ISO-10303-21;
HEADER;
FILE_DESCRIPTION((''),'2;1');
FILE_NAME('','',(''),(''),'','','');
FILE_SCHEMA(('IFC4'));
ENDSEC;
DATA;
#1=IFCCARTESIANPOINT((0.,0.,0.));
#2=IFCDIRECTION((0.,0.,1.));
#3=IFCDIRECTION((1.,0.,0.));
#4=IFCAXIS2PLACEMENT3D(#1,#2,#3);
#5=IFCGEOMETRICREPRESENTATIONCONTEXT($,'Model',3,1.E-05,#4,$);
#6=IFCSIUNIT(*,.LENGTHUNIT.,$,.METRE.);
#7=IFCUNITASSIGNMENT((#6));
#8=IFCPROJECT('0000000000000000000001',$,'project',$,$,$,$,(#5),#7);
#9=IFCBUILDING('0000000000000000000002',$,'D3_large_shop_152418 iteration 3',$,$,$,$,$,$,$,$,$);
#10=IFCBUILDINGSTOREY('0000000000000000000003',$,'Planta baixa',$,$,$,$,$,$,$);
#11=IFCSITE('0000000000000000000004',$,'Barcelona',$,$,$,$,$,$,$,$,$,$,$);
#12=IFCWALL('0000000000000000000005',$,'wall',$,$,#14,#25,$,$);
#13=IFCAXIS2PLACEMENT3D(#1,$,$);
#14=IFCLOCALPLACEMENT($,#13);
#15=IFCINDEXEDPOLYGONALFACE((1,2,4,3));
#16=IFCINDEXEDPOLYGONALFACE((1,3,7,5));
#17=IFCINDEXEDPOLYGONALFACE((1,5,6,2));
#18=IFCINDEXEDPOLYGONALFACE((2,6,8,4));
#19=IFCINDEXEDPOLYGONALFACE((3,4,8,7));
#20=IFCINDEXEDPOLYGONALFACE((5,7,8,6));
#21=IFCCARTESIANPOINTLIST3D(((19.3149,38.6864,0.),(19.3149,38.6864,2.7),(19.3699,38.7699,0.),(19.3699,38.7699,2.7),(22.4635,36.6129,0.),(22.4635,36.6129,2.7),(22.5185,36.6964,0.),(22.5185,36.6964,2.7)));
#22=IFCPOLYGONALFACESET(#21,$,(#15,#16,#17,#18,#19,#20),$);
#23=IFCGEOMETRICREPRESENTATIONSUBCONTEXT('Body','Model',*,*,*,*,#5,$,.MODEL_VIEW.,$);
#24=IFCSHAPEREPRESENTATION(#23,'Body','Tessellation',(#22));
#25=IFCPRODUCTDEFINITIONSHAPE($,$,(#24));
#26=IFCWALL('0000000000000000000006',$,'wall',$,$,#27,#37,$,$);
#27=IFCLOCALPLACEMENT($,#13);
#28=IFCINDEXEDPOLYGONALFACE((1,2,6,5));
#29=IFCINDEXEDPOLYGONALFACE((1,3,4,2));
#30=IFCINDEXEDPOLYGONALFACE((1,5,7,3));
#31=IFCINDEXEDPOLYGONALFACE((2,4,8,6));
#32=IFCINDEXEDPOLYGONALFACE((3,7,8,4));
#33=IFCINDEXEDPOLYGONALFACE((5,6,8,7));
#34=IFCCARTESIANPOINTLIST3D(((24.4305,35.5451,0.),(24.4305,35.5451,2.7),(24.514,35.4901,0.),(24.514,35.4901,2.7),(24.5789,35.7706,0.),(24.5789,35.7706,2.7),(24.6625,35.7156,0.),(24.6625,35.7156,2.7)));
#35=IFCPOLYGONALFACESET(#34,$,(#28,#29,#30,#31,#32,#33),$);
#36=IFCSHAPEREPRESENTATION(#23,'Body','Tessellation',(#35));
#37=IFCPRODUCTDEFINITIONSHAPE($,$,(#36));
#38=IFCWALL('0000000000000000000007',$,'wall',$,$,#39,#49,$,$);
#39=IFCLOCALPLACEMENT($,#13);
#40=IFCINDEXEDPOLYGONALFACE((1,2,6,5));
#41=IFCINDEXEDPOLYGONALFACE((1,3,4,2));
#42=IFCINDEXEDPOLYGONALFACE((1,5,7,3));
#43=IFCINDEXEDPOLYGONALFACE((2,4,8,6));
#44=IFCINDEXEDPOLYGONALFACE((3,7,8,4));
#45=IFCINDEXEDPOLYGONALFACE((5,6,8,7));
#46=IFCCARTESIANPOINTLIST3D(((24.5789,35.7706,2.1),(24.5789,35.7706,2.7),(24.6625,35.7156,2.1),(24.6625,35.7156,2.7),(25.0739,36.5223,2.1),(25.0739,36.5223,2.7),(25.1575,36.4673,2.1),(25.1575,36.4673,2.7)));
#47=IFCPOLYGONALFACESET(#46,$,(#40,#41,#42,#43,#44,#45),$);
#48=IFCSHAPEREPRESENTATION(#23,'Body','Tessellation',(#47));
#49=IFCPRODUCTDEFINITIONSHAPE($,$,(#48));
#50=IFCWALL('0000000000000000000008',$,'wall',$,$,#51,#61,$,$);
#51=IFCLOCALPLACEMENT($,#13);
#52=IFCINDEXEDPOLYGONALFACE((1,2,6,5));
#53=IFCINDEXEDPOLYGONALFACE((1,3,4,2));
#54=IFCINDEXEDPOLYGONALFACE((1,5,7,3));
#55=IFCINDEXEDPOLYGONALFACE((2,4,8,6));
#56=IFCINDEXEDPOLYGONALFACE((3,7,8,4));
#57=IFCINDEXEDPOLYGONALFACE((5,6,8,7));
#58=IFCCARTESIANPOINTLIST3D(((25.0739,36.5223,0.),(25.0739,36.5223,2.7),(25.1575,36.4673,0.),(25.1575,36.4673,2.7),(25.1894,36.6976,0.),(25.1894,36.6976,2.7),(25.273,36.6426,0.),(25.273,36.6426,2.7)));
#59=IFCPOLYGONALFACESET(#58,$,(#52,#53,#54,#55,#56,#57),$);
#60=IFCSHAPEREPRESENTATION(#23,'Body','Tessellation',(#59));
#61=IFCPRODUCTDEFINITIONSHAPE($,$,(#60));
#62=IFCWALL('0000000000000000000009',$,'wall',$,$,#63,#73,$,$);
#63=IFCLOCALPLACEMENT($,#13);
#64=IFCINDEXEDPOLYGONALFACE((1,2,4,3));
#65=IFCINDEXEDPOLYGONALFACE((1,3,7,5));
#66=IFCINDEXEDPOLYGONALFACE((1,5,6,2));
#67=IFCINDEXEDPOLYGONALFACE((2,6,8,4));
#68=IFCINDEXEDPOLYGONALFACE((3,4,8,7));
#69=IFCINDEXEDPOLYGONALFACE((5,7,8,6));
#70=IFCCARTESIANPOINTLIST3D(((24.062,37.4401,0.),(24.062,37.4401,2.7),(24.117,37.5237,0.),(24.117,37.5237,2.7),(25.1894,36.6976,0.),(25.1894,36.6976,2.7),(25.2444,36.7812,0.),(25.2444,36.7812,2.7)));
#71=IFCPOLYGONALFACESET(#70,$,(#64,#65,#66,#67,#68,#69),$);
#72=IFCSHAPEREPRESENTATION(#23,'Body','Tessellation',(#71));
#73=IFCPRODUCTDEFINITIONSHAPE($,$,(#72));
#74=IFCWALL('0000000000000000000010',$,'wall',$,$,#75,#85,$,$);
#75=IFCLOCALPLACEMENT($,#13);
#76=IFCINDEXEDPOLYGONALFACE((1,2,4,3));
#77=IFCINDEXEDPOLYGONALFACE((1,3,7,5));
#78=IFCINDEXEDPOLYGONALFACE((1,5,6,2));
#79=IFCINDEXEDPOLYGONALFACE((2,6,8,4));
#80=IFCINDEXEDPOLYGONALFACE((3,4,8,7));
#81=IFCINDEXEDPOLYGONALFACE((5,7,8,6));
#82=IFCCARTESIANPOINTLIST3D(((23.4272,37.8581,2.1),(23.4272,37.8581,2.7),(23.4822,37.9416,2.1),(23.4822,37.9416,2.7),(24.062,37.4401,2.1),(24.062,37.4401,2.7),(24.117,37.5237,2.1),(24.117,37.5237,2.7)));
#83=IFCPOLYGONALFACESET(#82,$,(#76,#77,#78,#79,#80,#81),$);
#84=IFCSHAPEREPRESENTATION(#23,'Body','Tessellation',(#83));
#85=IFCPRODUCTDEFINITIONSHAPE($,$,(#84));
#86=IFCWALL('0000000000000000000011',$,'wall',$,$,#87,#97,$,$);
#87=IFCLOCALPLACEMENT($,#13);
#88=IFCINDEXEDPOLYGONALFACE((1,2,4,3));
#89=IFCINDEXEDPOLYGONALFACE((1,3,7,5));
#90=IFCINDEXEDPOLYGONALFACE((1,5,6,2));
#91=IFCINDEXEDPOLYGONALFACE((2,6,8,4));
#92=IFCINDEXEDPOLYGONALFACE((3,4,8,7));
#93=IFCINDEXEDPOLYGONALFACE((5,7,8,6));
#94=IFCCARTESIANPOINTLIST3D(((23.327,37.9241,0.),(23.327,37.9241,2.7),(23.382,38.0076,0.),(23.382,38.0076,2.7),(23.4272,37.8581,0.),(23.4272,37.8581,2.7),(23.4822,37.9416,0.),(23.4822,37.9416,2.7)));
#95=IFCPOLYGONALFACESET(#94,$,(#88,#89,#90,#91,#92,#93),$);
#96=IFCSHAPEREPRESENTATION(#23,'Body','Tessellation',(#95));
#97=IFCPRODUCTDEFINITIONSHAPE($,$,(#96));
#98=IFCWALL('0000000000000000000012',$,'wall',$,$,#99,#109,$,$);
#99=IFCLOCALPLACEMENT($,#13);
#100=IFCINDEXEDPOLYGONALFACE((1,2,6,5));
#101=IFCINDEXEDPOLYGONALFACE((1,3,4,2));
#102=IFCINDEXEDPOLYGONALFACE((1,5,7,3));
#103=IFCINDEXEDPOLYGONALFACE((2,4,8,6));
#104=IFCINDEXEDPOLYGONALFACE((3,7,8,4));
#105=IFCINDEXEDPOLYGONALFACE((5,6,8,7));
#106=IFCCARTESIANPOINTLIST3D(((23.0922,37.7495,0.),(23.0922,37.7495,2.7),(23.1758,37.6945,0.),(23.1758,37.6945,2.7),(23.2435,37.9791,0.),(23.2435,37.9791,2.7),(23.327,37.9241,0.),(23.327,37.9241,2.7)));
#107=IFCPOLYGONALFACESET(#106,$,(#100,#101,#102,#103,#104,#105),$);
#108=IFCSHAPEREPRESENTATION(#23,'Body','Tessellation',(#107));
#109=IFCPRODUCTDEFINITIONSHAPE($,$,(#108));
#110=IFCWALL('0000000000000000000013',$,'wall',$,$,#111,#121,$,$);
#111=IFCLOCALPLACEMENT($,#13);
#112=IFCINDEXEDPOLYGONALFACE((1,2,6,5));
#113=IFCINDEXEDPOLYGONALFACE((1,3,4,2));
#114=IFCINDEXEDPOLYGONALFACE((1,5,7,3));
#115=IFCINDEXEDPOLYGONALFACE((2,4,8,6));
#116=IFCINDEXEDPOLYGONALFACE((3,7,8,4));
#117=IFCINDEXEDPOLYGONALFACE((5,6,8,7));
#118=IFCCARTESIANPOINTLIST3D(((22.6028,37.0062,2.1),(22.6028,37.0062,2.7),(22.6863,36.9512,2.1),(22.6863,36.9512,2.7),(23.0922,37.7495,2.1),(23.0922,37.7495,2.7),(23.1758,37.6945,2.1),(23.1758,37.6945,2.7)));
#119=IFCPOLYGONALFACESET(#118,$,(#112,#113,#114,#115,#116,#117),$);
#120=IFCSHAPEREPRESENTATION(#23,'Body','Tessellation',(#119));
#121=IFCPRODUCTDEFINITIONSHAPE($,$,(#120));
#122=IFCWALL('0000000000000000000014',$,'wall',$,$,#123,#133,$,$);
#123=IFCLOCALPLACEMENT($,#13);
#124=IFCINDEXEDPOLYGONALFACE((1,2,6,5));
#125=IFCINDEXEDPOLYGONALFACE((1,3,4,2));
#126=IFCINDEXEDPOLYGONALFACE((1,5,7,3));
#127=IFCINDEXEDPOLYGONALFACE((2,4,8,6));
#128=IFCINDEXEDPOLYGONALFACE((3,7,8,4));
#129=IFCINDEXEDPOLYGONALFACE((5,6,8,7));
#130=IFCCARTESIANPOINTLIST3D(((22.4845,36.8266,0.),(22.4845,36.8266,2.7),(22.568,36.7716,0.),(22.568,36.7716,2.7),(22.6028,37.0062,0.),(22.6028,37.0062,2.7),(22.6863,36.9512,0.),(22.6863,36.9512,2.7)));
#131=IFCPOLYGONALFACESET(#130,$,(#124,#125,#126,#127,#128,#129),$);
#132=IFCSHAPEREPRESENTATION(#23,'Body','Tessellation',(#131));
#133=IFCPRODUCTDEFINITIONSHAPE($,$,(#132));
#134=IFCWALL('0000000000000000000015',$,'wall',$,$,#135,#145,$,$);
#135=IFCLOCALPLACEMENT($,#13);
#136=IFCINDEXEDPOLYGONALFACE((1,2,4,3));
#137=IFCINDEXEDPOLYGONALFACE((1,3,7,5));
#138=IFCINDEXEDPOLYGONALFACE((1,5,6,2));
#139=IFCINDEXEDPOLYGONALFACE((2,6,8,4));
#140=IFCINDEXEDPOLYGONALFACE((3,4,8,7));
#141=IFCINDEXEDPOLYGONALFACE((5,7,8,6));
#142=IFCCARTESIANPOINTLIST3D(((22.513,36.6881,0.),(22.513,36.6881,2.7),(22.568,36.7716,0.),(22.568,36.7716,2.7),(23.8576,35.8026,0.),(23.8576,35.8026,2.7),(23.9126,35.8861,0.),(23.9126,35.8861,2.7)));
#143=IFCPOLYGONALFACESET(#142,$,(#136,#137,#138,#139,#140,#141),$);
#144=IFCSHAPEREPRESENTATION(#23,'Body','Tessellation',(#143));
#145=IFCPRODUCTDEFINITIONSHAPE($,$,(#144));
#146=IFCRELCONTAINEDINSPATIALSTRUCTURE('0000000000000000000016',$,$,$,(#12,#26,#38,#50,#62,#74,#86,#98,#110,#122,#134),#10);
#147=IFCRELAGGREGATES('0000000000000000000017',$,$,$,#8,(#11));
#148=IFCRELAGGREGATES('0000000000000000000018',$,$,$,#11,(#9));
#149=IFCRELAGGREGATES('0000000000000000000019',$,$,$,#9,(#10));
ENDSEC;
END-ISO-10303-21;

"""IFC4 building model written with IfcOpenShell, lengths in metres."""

from ifc_helpers import new_model, si_unit, frame, origin, origin_with_axes, place, context, subcontext, project, spatial, polyline, outline, extrude, element, save


model = new_model("IFC4")

# Units and contexts
model_context = context("Model", 3, precision=1e-05, world=origin_with_axes())
body_context = subcontext(model_context, "Body", "Model", "MODEL_VIEW")
ifc_project = project(units=[si_unit("LENGTHUNIT", "METRE")], contexts=[model_context])

# Site, building, storey
site = spatial("IfcSite", under=ifc_project, Name="Barcelona")
building = spatial("IfcBuilding", under=site, Name="D3_large_shop_152418 iteration 3")
storey = spatial("IfcBuildingStorey", under=building, Name="Planta baixa")

# Walls
wall_1_placement = place(None, origin_with_axes())
element("IfcWall", 1, at=wall_1_placement, inside=storey, Name="wall", context=body_context, shape_type="SweptSolid", body=[
    extrude(outline(polyline([(22.4635, 36.6129), (19.3149, 38.6864), (19.3699, 38.7699), (22.5185, 36.6964), (22.4635, 36.6129)])), origin(), (0.0, 0.0, 1.0), 2.7),
])
wall_2_placement = place(None, origin_with_axes())
element("IfcWall", 2, at=wall_2_placement, inside=storey, Name="wall", context=body_context, shape_type="SweptSolid", body=[
    extrude(outline(polyline([(24.4305, 35.5451), (24.5789, 35.7706), (24.6625, 35.7156), (24.514, 35.4901), (24.4305, 35.5451)])), origin(), (0.0, 0.0, 1.0), 2.7),
])
wall_3_placement = place(None, origin_with_axes())
element("IfcWall", 3, at=wall_3_placement, inside=storey, Name="wall", context=body_context, shape_type="SweptSolid", body=[
    extrude(outline(polyline([(24.5789, 35.7706), (25.0739, 36.5223), (25.1575, 36.4673), (24.6625, 35.7156), (24.5789, 35.7706)])), frame((0.0, 0.0, 2.1)), (0.0, 0.0, 1.0), 0.6),
])
wall_4_placement = place(None, origin_with_axes())
element("IfcWall", 4, at=wall_4_placement, inside=storey, Name="wall", context=body_context, shape_type="SweptSolid", body=[
    extrude(outline(polyline([(25.0739, 36.5223), (25.1894, 36.6976), (25.273, 36.6426), (25.1575, 36.4673), (25.0739, 36.5223)])), origin(), (0.0, 0.0, 1.0), 2.7),
])
wall_5_placement = place(None, origin_with_axes())
element("IfcWall", 5, at=wall_5_placement, inside=storey, Name="wall", context=body_context, shape_type="SweptSolid", body=[
    extrude(outline(polyline([(25.1894, 36.6976), (24.062, 37.4401), (24.117, 37.5237), (25.2444, 36.7812), (25.1894, 36.6976)])), origin(), (0.0, 0.0, 1.0), 2.7),
])
wall_6_placement = place(None, origin_with_axes())
element("IfcWall", 6, at=wall_6_placement, inside=storey, Name="wall", context=body_context, shape_type="SweptSolid", body=[
    extrude(outline(polyline([(24.062, 37.4401), (23.4272, 37.8581), (23.4822, 37.9416), (24.117, 37.5237), (24.062, 37.4401)])), frame((0.0, 0.0, 2.1)), (0.0, 0.0, 1.0), 0.6),
])
wall_7_placement = place(None, origin_with_axes())
element("IfcWall", 7, at=wall_7_placement, inside=storey, Name="wall", context=body_context, shape_type="SweptSolid", body=[
    extrude(outline(polyline([(23.4272, 37.8581), (23.327, 37.9241), (23.382, 38.0076), (23.4822, 37.9416), (23.4272, 37.8581)])), origin(), (0.0, 0.0, 1.0), 2.7),
])
wall_8_placement = place(None, origin_with_axes())
element("IfcWall", 8, at=wall_8_placement, inside=storey, Name="wall", context=body_context, shape_type="SweptSolid", body=[
    extrude(outline(polyline([(23.327, 37.9241), (23.1758, 37.6945), (23.0922, 37.7495), (23.2435, 37.9791), (23.327, 37.9241)])), origin(), (0.0, 0.0, 1.0), 2.7),
])
wall_9_placement = place(None, origin_with_axes())
element("IfcWall", 9, at=wall_9_placement, inside=storey, Name="wall", context=body_context, shape_type="SweptSolid", body=[
    extrude(outline(polyline([(23.1758, 37.6945), (22.6863, 36.9512), (22.6028, 37.0062), (23.0922, 37.7495), (23.1758, 37.6945)])), frame((0.0, 0.0, 2.1)), (0.0, 0.0, 1.0), 0.6),
])
wall_10_placement = place(None, origin_with_axes())
element("IfcWall", 10, at=wall_10_placement, inside=storey, Name="wall", context=body_context, shape_type="SweptSolid", body=[
    extrude(outline(polyline([(22.6863, 36.9512), (22.568, 36.7716), (22.4845, 36.8266), (22.6028, 37.0062), (22.6863, 36.9512)])), origin(), (0.0, 0.0, 1.0), 2.7),
])
wall_11_placement = place(None, origin_with_axes())
element("IfcWall", 11, at=wall_11_placement, inside=storey, Name="wall", context=body_context, shape_type="SweptSolid", body=[
    extrude(outline(polyline([(22.568, 36.7716), (23.9126, 35.8861), (23.8576, 35.8026), (22.513, 36.6881), (22.568, 36.7716)])), origin(), (0.0, 0.0, 1.0), 2.7),
])

save(model, "model.ifc")
